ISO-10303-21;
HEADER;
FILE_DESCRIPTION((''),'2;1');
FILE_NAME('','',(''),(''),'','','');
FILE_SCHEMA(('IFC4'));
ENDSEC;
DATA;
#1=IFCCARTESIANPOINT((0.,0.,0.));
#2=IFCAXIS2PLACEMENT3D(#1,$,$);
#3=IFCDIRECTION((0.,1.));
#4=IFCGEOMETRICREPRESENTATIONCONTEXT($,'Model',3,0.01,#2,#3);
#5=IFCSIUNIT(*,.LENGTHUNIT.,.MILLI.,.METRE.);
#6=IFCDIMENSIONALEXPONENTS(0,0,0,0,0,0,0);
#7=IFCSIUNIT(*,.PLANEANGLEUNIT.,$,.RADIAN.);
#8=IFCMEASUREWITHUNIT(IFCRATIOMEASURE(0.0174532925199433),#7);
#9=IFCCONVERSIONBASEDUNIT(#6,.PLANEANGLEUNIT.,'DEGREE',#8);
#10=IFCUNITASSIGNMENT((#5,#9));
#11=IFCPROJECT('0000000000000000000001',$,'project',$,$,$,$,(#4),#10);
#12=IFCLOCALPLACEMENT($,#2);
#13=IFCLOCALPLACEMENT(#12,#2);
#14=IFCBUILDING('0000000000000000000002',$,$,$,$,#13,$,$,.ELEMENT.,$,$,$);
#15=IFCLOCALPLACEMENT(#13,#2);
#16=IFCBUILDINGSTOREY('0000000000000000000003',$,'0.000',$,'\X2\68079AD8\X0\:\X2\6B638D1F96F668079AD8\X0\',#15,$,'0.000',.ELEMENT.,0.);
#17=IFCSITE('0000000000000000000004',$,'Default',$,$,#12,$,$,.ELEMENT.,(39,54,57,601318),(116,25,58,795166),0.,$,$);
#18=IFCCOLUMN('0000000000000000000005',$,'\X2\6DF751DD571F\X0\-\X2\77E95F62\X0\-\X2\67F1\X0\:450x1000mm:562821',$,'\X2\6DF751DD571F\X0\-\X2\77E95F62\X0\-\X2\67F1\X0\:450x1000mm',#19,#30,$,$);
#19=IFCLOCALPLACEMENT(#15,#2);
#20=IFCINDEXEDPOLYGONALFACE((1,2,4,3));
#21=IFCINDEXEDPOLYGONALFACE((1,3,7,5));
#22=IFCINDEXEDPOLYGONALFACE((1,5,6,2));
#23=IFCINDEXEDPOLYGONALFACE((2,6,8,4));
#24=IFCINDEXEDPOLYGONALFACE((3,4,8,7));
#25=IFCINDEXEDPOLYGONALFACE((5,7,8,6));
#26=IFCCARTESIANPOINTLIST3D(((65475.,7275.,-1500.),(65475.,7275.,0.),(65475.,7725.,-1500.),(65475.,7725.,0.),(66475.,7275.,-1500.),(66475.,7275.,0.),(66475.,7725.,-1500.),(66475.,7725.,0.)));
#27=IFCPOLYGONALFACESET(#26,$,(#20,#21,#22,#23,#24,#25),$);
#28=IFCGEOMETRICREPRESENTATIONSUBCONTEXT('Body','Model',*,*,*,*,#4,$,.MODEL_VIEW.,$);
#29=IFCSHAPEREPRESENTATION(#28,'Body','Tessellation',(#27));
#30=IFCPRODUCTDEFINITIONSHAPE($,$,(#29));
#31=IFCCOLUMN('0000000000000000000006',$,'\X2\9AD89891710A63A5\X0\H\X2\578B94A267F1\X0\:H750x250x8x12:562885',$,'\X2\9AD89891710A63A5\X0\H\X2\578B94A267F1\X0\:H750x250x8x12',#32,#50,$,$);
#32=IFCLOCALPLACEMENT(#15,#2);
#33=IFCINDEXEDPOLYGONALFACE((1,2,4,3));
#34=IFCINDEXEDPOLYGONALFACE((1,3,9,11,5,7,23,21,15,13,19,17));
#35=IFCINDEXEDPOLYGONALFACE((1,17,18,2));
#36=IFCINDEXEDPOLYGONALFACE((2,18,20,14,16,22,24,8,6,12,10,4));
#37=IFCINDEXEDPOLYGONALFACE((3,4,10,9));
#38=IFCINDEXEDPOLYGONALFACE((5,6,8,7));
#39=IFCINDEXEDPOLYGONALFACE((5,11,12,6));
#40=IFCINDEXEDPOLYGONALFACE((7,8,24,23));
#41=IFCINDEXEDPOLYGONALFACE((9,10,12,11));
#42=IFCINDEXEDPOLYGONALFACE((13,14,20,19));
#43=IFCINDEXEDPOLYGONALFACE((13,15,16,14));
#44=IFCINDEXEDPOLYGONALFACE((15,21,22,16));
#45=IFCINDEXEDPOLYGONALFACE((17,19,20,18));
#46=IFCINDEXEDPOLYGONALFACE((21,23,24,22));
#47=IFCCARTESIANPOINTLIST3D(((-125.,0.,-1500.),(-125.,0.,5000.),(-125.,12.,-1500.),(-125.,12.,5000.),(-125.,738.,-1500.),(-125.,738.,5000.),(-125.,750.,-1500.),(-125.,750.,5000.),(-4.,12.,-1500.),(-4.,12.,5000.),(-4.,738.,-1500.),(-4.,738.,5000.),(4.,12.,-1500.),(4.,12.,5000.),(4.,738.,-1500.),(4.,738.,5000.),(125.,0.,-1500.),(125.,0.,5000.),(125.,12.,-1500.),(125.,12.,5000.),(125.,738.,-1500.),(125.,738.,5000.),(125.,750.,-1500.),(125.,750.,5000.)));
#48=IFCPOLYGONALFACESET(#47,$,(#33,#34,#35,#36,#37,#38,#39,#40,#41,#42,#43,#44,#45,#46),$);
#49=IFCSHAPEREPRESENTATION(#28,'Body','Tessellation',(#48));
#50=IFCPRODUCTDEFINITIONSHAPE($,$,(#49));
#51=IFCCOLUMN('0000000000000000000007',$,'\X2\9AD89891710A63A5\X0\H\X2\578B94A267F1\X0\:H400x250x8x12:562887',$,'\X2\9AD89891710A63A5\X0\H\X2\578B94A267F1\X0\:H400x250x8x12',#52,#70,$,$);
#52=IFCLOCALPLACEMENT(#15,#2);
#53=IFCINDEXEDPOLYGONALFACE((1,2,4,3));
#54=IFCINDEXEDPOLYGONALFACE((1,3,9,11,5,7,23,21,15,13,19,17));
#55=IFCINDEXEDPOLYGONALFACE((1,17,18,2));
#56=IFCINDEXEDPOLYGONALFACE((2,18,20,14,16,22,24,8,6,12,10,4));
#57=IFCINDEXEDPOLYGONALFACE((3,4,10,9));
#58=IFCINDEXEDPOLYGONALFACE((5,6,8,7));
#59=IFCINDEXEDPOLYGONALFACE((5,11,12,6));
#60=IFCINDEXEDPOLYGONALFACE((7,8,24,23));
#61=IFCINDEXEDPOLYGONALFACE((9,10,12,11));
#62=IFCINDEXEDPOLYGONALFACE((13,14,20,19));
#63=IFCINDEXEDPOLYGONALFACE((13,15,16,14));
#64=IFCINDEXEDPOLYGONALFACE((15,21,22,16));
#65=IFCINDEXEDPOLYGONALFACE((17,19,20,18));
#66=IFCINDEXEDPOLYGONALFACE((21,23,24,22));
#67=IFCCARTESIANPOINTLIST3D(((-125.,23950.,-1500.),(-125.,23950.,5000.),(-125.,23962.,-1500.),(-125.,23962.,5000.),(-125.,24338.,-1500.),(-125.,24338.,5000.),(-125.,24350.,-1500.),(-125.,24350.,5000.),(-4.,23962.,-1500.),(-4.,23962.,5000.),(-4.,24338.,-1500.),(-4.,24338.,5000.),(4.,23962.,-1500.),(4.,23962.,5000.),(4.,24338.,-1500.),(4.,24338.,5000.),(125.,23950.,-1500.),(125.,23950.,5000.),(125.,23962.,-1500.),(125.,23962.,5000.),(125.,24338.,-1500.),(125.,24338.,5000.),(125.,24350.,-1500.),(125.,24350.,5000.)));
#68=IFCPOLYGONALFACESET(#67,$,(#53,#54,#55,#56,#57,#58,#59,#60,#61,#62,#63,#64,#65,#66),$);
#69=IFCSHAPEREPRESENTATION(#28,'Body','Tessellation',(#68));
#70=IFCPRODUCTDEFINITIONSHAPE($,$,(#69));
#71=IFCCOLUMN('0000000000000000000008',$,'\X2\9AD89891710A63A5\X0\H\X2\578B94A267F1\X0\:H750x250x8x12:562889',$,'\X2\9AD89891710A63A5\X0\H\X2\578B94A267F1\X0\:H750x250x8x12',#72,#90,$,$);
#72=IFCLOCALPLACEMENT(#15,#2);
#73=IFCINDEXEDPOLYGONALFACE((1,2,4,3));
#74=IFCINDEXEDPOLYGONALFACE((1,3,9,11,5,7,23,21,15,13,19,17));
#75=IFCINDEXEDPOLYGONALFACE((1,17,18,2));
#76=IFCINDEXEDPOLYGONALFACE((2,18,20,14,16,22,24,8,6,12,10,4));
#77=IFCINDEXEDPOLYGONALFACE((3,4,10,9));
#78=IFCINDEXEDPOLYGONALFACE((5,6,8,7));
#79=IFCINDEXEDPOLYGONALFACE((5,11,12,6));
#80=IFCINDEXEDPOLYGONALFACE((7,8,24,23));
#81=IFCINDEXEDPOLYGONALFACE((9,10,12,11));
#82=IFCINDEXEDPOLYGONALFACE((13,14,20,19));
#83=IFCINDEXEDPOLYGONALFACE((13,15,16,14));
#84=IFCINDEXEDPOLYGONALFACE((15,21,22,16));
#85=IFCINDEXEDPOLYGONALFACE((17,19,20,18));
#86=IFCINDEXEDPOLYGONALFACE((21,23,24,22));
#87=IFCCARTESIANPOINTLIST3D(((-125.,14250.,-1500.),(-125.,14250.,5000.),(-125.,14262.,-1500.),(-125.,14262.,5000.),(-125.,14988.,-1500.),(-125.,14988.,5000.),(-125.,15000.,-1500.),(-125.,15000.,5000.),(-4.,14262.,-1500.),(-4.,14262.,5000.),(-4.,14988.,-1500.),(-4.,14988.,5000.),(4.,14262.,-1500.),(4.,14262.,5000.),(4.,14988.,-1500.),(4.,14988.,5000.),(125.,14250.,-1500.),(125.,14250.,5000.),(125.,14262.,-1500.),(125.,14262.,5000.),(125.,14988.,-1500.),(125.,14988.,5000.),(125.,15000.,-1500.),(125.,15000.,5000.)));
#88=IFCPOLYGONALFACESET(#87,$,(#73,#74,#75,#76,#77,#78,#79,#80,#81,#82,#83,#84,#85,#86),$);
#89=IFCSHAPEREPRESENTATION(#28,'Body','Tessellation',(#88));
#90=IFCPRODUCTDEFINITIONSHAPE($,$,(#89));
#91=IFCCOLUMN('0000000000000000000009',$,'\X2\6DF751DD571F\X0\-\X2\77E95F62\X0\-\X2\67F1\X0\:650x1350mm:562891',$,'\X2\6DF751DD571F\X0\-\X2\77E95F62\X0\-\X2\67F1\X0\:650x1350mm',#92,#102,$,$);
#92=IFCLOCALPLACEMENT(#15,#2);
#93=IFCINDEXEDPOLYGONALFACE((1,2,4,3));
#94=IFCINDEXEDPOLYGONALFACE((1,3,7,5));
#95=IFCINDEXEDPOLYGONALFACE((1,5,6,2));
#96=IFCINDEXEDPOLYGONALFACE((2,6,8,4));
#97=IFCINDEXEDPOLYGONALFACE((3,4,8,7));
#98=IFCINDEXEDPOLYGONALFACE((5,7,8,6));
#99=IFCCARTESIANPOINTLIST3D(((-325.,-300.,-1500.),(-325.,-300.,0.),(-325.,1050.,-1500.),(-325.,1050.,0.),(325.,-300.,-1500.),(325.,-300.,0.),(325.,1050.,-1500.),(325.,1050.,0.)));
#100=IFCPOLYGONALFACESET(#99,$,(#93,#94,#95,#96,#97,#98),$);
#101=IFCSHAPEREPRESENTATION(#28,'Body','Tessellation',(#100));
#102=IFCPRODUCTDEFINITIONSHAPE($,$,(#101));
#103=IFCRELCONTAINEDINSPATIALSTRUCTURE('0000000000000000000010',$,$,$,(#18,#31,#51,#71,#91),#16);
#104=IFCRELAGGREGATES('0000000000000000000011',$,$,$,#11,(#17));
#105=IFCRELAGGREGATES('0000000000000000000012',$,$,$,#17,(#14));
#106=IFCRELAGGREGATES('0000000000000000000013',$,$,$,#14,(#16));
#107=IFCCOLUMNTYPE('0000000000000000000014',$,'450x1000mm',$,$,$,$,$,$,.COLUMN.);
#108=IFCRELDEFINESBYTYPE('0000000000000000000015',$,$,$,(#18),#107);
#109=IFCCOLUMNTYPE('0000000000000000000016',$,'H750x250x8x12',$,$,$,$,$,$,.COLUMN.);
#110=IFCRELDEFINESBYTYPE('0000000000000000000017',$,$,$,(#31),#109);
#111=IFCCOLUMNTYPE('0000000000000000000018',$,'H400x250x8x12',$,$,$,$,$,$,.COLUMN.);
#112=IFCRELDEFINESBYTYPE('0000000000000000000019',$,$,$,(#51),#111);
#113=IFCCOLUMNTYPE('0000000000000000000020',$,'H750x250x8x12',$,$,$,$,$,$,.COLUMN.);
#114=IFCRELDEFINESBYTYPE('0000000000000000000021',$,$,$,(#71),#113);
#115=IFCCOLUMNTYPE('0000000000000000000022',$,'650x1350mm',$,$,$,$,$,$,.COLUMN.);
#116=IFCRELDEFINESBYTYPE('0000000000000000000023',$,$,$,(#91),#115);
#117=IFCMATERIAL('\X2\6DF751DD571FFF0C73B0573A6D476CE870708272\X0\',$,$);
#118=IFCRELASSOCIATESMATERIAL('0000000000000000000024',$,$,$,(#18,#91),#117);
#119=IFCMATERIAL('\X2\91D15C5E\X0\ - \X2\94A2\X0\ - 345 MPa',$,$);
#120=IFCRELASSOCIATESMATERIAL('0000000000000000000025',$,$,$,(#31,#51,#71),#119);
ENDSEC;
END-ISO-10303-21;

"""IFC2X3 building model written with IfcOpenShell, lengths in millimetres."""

from ifc_helpers import new_model, entity, si_unit, converted_unit, direction, frame, origin, origin_2d_with_axis, place, context, subcontext, project, spatial, polyline, rectangle, outline, extrude, source, transform, mapped, material, type_object, type_shapes, element, save


model = new_model("IFC2X3")

# Units and contexts
model_context = context("Model", 3, precision=0.01, world=origin(), true_north=direction((0.0, 1.0)))
body_context = subcontext(model_context, "Body", "Model", "MODEL_VIEW")
ifc_project = project(units=[si_unit("LENGTHUNIT", "METRE", prefix="MILLI"), converted_unit("PLANEANGLEUNIT", "DEGREE", entity("IfcRatioMeasure", 0.0174532925199433), si_unit("PLANEANGLEUNIT", "RADIAN"), dimensions=[0, 0, 0, 0, 0, 0, 0])], contexts=[model_context])

# Site, building, storey
site_placement = place(None, origin())
site = spatial("IfcSite", under=ifc_project, at=site_placement, Name="Default", CompositionType="ELEMENT", RefLatitude=(39, 54, 57, 601318), RefLongitude=(116, 25, 58, 795166), RefElevation=0.0)
building_placement = place(site_placement, origin())
building = spatial("IfcBuilding", under=site, at=building_placement, CompositionType="ELEMENT")
storey_placement = place(building_placement, origin())
storey = spatial("IfcBuildingStorey", under=building, at=storey_placement, Name="0.000", ObjectType="标高:正负零标高", LongName="0.000", CompositionType="ELEMENT", Elevation=0.0)

# Columns
ifc_material_1 = material(Name="混凝土，现场浇注灰色")
ifc_material_2 = material(Name="金属 - 钢 - 345 MPa")
column_type_1 = type_object("IfcColumnType", Name="450x1000mm", PredefinedType="COLUMN")
shared_shape_1 = source(origin(), body_context, "Body", "SweptSolid", [
    extrude(rectangle(XDim=450.0, YDim=1000.0, at=origin_2d_with_axis()), frame((65975.0, 7500.0, -1500.0), z_axis=(0.0, 0.0, 1.0), x_axis=(0.0, -1.0, 0.0)), (0.0, 0.0, 1.0), 1500.0),
])
type_shapes(column_type_1, [shared_shape_1])
column_1_placement = place(storey_placement, origin())
element("IfcColumn", 1, at=column_1_placement, inside=storey, type_object=column_type_1, material=ifc_material_1, Name="混凝土-矩形-柱:450x1000mm:562821", ObjectType="混凝土-矩形-柱:450x1000mm", context=body_context, shape_type="MappedRepresentation", body=[
    mapped(shared_shape_1, transform((0.0, 0.0, 0.0), scale=1.0)),
])
column_type_2 = type_object("IfcColumnType", Name="H750x250x8x12", PredefinedType="COLUMN")
shared_shape_2 = source(origin(), body_context, "Body", "SweptSolid", [
    extrude(outline(polyline([(363.0, -125.0), (375.0, -125.0), (375.0, 125.0), (363.0, 125.0), (363.0, 4.0), (-363.0, 4.0), (-363.0, 125.0), (-375.0, 125.0), (-375.0, -125.0), (-363.0, -125.0), (-363.0, -4.0), (363.0, -4.0), (363.0, -125.0)])), frame((0.0, 375.0, -1500.0), z_axis=(0.0, 0.0, 1.0), x_axis=(0.0, -1.0, 0.0)), (0.0, 0.0, 1.0), 6500.0),
])
type_shapes(column_type_2, [shared_shape_2])
column_2_placement = place(storey_placement, origin())
element("IfcColumn", 2, at=column_2_placement, inside=storey, type_object=column_type_2, material=ifc_material_2, Name="高频焊接H型钢柱:H750x250x8x12:562885", ObjectType="高频焊接H型钢柱:H750x250x8x12", context=body_context, shape_type="MappedRepresentation", body=[
    mapped(shared_shape_2, transform((0.0, 0.0, 0.0), scale=1.0)),
])
column_type_3 = type_object("IfcColumnType", Name="H400x250x8x12", PredefinedType="COLUMN")
shared_shape_3 = source(origin(), body_context, "Body", "SweptSolid", [
    extrude(outline(polyline([(188.0, -125.0), (200.0, -125.0), (200.0, 125.0), (188.0, 125.0), (188.0, 4.0), (-188.0, 4.0), (-188.0, 125.0), (-200.0, 125.0), (-200.0, -125.0), (-188.0, -125.0), (-188.0, -4.0), (188.0, -4.0), (188.0, -125.0)])), frame((0.0, 24150.0, -1500.0), z_axis=(0.0, 0.0, 1.0), x_axis=(0.0, -1.0, 0.0)), (0.0, 0.0, 1.0), 6500.0),
])
type_shapes(column_type_3, [shared_shape_3])
column_3_placement = place(storey_placement, origin())
element("IfcColumn", 3, at=column_3_placement, inside=storey, type_object=column_type_3, material=ifc_material_2, Name="高频焊接H型钢柱:H400x250x8x12:562887", ObjectType="高频焊接H型钢柱:H400x250x8x12", context=body_context, shape_type="MappedRepresentation", body=[
    mapped(shared_shape_3, transform((0.0, 0.0, 0.0), scale=1.0)),
])
column_type_4 = type_object("IfcColumnType", Name="H750x250x8x12", PredefinedType="COLUMN")
shared_shape_4 = source(origin(), body_context, "Body", "SweptSolid", [
    extrude(outline(polyline([(363.0, -125.0), (375.0, -125.0), (375.0, 125.0), (363.0, 125.0), (363.0, 4.0), (-363.0, 4.0), (-363.0, 125.0), (-375.0, 125.0), (-375.0, -125.0), (-363.0, -125.0), (-363.0, -4.0), (363.0, -4.0), (363.0, -125.0)])), frame((0.0, 14625.0, -1500.0), z_axis=(0.0, 0.0, 1.0), x_axis=(0.0, -1.0, 0.0)), (0.0, 0.0, 1.0), 6500.0),
])
type_shapes(column_type_4, [shared_shape_4])
column_4_placement = place(storey_placement, origin())
element("IfcColumn", 4, at=column_4_placement, inside=storey, type_object=column_type_4, material=ifc_material_2, Name="高频焊接H型钢柱:H750x250x8x12:562889", ObjectType="高频焊接H型钢柱:H750x250x8x12", context=body_context, shape_type="MappedRepresentation", body=[
    mapped(shared_shape_4, transform((0.0, 0.0, 0.0), scale=1.0)),
])
column_type_5 = type_object("IfcColumnType", Name="650x1350mm", PredefinedType="COLUMN")
shared_shape_5 = source(origin(), body_context, "Body", "SweptSolid", [
    extrude(rectangle(XDim=1350.0, YDim=650.0, at=origin_2d_with_axis()), frame((0.0, 375.0, -1500.0), z_axis=(0.0, 0.0, 1.0), x_axis=(0.0, -1.0, 0.0)), (0.0, 0.0, 1.0), 1500.0),
])
type_shapes(column_type_5, [shared_shape_5])
column_5_placement = place(storey_placement, origin())
element("IfcColumn", 5, at=column_5_placement, inside=storey, type_object=column_type_5, material=ifc_material_1, Name="混凝土-矩形-柱:650x1350mm:562891", ObjectType="混凝土-矩形-柱:650x1350mm", context=body_context, shape_type="MappedRepresentation", body=[
    mapped(shared_shape_5, transform((0.0, 0.0, 0.0), scale=1.0)),
])

save(model, "model.ifc")
